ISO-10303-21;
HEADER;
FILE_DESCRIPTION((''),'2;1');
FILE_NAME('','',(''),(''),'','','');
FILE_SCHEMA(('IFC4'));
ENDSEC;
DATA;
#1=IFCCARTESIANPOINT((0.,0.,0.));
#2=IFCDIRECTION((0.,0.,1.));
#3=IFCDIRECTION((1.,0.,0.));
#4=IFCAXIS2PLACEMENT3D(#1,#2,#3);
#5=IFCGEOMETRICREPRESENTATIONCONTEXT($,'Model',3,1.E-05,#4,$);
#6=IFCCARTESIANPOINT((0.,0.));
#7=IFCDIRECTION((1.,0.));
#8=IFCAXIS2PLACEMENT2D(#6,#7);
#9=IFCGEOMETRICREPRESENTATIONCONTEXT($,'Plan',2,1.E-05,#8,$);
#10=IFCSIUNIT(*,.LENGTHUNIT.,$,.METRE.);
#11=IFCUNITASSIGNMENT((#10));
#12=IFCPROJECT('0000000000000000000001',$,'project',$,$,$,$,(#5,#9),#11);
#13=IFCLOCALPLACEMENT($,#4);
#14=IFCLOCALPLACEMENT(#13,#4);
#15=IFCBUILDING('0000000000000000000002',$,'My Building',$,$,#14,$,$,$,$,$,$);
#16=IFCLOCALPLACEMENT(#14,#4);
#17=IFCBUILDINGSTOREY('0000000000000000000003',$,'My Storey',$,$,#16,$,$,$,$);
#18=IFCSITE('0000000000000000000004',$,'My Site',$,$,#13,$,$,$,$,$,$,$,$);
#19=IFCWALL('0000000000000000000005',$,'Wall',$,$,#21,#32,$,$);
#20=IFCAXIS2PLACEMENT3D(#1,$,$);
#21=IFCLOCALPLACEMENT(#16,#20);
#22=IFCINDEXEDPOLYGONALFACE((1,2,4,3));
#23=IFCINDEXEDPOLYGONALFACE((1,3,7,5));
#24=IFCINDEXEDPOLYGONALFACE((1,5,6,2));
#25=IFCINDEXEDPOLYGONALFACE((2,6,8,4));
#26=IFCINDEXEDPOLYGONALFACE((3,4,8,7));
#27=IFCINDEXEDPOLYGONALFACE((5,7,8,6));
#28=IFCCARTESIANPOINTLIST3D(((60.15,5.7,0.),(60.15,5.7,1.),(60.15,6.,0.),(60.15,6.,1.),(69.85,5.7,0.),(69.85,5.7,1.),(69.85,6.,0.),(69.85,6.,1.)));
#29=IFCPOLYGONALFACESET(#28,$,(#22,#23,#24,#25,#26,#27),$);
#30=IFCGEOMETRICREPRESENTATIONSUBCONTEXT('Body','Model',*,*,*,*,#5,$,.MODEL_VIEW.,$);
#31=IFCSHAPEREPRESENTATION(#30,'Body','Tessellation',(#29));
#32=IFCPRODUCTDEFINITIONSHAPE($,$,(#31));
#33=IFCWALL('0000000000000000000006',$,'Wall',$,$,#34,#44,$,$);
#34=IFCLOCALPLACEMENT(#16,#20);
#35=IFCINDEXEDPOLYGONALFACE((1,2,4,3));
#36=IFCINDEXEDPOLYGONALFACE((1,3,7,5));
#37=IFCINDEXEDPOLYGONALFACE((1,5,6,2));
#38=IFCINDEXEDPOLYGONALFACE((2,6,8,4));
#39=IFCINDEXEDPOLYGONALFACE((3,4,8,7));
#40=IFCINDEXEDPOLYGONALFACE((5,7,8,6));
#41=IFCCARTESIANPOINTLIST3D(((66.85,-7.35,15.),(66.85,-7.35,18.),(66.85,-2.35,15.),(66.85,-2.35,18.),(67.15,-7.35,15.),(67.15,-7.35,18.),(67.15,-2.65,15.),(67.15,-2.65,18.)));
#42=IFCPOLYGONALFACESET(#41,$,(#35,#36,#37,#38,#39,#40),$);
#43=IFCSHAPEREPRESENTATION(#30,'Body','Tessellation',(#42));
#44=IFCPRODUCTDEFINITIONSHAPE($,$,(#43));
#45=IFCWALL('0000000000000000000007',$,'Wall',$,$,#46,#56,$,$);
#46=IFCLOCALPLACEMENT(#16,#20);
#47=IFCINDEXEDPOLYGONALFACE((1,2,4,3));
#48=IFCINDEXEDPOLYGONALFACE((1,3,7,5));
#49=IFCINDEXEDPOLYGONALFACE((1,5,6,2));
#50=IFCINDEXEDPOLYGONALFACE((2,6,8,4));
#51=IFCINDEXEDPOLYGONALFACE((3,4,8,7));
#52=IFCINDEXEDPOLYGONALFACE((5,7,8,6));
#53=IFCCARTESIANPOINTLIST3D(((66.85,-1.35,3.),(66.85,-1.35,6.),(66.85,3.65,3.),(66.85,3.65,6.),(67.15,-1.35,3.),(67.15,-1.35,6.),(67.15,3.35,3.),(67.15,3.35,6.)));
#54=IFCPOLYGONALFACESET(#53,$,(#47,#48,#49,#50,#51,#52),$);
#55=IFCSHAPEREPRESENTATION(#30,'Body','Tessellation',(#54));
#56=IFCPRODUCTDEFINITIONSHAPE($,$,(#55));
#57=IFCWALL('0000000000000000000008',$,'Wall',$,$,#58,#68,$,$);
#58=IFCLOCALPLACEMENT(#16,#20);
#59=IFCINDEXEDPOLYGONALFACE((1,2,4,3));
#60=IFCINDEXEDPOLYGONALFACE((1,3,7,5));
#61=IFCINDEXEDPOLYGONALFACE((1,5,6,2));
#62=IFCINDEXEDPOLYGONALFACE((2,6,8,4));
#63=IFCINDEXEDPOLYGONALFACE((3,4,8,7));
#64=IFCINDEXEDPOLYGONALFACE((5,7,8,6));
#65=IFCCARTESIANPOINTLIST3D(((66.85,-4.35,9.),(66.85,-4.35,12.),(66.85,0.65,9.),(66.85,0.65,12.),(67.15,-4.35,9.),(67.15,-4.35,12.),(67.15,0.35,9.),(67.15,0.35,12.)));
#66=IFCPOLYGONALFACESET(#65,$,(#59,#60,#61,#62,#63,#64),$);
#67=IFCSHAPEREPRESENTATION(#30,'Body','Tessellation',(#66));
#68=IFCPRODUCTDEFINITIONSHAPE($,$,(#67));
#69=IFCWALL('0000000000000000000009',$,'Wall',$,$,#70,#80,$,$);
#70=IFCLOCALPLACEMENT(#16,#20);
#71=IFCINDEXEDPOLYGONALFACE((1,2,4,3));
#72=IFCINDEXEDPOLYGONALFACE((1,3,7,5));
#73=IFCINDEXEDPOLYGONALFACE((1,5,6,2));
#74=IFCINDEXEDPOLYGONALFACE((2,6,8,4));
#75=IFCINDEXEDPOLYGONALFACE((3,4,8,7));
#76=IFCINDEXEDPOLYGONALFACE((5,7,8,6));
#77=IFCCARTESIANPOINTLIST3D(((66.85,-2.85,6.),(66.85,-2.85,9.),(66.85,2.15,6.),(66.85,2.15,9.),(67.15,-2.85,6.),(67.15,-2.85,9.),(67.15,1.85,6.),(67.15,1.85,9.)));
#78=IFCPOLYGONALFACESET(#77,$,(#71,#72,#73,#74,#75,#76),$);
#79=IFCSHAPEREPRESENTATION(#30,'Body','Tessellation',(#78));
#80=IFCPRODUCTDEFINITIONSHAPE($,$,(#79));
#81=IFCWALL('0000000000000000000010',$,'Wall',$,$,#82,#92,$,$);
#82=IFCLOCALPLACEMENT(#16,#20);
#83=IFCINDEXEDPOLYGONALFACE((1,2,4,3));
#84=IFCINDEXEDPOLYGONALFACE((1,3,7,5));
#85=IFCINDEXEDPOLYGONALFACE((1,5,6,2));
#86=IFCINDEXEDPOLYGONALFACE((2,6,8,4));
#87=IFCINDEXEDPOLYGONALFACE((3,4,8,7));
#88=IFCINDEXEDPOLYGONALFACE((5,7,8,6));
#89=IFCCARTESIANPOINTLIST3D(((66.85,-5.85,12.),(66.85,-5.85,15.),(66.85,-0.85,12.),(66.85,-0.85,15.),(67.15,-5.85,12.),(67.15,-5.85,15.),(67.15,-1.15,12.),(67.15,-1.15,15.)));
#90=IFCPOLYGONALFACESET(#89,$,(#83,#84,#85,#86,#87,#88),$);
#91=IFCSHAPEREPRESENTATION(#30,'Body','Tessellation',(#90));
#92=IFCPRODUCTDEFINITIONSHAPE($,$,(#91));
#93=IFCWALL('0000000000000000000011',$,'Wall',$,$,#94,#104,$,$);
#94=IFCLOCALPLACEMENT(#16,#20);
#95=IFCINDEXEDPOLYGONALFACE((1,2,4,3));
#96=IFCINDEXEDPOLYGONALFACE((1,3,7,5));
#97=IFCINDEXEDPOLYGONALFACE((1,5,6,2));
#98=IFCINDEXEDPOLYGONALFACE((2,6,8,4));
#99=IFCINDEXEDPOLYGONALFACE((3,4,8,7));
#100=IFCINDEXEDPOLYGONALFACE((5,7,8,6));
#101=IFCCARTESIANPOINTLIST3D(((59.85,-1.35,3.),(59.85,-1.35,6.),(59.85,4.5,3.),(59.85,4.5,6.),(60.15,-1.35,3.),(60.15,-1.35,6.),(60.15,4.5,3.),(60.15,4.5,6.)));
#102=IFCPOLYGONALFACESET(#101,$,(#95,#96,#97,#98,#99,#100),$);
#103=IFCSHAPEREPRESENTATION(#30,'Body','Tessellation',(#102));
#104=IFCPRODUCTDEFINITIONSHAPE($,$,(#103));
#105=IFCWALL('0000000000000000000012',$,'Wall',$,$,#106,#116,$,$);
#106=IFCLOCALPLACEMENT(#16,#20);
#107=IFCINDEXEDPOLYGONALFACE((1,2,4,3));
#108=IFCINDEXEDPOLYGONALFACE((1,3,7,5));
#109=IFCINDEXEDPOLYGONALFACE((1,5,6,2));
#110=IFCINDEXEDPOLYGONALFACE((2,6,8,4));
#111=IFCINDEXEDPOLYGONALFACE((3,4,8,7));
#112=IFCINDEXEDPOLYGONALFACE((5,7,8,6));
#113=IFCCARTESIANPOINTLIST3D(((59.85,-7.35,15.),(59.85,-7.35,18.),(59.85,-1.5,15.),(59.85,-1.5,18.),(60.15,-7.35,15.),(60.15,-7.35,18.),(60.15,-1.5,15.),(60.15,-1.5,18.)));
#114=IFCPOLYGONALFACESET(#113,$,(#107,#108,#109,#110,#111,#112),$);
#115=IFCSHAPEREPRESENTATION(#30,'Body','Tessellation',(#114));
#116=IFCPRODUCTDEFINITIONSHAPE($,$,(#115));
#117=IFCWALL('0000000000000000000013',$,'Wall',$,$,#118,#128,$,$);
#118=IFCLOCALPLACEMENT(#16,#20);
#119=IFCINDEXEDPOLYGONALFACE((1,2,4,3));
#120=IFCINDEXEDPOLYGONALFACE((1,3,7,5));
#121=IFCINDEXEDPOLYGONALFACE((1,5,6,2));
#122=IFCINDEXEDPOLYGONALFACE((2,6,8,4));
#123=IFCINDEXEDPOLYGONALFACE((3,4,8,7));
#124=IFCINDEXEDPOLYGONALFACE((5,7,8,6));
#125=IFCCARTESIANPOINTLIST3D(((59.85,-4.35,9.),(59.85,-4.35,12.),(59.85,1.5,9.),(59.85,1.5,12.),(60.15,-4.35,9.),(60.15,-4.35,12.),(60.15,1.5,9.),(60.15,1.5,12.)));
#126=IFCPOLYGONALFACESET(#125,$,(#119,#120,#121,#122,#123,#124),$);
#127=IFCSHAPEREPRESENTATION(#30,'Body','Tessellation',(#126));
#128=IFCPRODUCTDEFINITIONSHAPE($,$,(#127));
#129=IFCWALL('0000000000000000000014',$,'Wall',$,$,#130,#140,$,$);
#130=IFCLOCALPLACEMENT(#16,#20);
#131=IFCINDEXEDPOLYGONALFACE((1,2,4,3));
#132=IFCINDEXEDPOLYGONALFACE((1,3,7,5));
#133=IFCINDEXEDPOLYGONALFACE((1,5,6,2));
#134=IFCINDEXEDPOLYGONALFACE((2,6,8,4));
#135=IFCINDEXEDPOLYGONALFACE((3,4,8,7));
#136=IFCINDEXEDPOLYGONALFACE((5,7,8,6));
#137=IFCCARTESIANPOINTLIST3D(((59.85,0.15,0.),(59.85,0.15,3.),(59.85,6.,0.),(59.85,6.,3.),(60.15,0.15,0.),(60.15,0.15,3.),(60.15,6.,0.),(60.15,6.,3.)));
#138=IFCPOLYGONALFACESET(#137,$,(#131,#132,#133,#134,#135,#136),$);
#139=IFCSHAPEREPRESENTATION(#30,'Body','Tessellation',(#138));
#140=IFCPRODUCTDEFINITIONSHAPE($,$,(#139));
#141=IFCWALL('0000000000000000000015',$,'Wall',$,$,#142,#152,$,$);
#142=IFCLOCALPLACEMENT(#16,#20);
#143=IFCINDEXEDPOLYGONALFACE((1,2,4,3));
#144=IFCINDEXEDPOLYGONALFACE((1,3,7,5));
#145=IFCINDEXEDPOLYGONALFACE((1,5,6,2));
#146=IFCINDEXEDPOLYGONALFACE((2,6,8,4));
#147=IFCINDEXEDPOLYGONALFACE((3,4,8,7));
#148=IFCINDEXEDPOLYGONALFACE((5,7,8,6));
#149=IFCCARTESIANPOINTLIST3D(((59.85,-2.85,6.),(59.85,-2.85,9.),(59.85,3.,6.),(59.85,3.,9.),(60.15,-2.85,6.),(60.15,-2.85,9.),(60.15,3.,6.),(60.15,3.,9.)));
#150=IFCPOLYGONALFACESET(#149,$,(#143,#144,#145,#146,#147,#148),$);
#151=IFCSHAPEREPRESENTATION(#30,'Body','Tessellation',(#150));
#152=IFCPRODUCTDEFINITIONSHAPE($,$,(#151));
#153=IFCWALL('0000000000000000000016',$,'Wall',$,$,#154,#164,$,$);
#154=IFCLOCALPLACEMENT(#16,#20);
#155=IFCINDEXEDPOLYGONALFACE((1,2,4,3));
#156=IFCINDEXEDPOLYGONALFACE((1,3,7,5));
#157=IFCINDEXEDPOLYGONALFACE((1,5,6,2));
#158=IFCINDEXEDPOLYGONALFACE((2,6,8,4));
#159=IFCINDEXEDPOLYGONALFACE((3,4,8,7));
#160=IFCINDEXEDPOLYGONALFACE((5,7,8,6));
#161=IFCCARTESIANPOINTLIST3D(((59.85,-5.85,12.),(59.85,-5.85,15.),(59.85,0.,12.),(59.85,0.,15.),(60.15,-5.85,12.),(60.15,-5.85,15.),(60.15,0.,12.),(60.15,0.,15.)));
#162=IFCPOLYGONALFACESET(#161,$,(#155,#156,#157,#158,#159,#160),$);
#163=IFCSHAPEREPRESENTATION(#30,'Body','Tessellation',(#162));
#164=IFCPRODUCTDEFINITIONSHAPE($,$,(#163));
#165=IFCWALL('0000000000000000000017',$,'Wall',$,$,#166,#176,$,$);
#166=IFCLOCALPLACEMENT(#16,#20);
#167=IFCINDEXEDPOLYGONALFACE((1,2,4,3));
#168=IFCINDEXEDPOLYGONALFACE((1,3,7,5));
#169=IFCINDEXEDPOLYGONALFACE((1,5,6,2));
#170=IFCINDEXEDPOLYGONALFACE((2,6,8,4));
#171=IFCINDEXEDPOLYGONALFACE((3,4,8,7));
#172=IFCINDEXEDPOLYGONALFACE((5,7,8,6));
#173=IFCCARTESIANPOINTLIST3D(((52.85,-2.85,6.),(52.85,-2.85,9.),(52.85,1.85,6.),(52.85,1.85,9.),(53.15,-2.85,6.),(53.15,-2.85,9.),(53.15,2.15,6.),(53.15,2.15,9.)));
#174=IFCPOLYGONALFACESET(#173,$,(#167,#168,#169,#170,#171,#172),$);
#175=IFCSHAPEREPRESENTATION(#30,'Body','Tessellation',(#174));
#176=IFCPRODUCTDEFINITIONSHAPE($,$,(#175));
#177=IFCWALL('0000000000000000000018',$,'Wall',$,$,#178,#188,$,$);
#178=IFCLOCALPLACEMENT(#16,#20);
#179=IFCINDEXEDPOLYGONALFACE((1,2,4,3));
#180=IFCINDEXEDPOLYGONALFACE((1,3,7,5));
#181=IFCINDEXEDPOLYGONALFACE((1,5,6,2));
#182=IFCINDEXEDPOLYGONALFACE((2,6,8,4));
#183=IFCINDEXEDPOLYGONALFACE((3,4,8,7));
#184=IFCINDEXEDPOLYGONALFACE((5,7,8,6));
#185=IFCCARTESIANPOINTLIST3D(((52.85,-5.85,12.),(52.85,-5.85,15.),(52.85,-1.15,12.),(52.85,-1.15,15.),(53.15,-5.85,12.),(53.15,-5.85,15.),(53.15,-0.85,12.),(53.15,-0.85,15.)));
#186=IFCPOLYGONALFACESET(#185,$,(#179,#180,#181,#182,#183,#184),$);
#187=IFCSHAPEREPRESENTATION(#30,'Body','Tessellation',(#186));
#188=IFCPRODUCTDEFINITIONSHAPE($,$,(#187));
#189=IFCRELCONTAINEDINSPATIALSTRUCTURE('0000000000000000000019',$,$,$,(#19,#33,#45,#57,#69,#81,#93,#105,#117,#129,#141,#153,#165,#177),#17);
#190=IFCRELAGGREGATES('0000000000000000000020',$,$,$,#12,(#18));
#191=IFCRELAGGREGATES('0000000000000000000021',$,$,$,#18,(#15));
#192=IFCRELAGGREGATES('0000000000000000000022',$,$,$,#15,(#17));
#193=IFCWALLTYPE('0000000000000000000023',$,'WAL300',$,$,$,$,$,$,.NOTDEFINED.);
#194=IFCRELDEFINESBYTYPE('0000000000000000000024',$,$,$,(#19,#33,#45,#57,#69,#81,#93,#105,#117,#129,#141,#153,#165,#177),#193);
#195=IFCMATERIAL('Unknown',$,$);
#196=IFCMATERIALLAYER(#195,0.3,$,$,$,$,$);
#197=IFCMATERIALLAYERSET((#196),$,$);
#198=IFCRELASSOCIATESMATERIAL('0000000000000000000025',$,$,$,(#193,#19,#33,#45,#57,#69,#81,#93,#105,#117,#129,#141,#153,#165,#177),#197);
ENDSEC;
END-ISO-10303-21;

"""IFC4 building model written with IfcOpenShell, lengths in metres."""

from ifc_helpers import new_model, si_unit, frame, origin_with_axes, origin_2d_with_axis, place, context, subcontext, project, spatial, line, indexed_curve, outline, extrude, material, layer, layer_set, layer_usage, type_object, element, save


model = new_model("IFC4")

# Units and contexts
model_context = context("Model", 3, precision=1e-05, world=origin_with_axes())
plan_context = context("Plan", 2, precision=1e-05, world=origin_2d_with_axis())
body_context = subcontext(model_context, "Body", "Model", "MODEL_VIEW")
ifc_project = project(units=[si_unit("LENGTHUNIT", "METRE")], contexts=[model_context, plan_context])

# Site, building, storey
site_placement = place(None, origin_with_axes())
site = spatial("IfcSite", under=ifc_project, at=site_placement, Name="My Site")
building_placement = place(site_placement, origin_with_axes())
building = spatial("IfcBuilding", under=site, at=building_placement, Name="My Building")
storey_placement = place(building_placement, origin_with_axes())
storey = spatial("IfcBuildingStorey", under=building, at=storey_placement, Name="My Storey")

# Walls
ifc_material = material(Name="Unknown")
ifc_layer = layer(ifc_material, 0.3)
ifc_layer_set = layer_set([ifc_layer])
ifc_layer_usage_1 = layer_usage(ifc_layer_set, "AXIS2", "POSITIVE", -0.3)
wall_type = type_object("IfcWallType", Name="WAL300", PredefinedType="NOTDEFINED", material=ifc_layer_set)
wall_1_placement = place(storey_placement, frame((60.15, 6.0, 0.0), z_axis=(0.0, 0.0, 1.0), x_axis=(1.0, 0.0, 0.0)))
element("IfcWall", 1, at=wall_1_placement, inside=storey, type_object=wall_type, material=ifc_layer_usage_1, Name="Wall", context=body_context, shape_type="SweptSolid", body=[
    extrude(outline(indexed_curve([(0.0, -0.3), (0.0, 0.0), (9.7, 0.0), (9.7, -0.3)], segments=[line(1, 2, 3, 4, 1)])), origin_with_axes(), (0.0, 0.0, 1.0), 1.0),
])
ifc_layer_usage_2 = layer_usage(ifc_layer_set, "AXIS2", "POSITIVE", -0.15)
wall_2_placement = place(storey_placement, frame((67.0, -2.5, 15.0), z_axis=(0.0, 0.0, 1.0), x_axis=(0.0, -1.0, 0.0)))
element("IfcWall", 2, at=wall_2_placement, inside=storey, type_object=wall_type, material=ifc_layer_usage_2, Name="Wall", context=body_context, shape_type="SweptSolid", body=[
    extrude(outline(indexed_curve([(-0.15, -0.15), (0.15, 0.15), (4.85, 0.15), (4.85, -0.15)], segments=[line(1, 2, 3, 4, 1)])), origin_with_axes(), (0.0, 0.0, 1.0), 3.0),
])
ifc_layer_usage_3 = layer_usage(ifc_layer_set, "AXIS2", "POSITIVE", -0.15)
wall_3_placement = place(storey_placement, frame((67.0, 3.5, 3.0), z_axis=(0.0, 0.0, 1.0), x_axis=(0.0, -1.0, 0.0)))
element("IfcWall", 3, at=wall_3_placement, inside=storey, type_object=wall_type, material=ifc_layer_usage_3, Name="Wall", context=body_context, shape_type="SweptSolid", body=[
    extrude(outline(indexed_curve([(-0.15, -0.15), (0.15, 0.15), (4.85, 0.15), (4.85, -0.15)], segments=[line(1, 2, 3, 4, 1)])), origin_with_axes(), (0.0, 0.0, 1.0), 3.0),
])
ifc_layer_usage_4 = layer_usage(ifc_layer_set, "AXIS2", "POSITIVE", -0.15)
wall_4_placement = place(storey_placement, frame((67.0, 0.5, 9.0), z_axis=(0.0, 0.0, 1.0), x_axis=(0.0, -1.0, 0.0)))
element("IfcWall", 4, at=wall_4_placement, inside=storey, type_object=wall_type, material=ifc_layer_usage_4, Name="Wall", context=body_context, shape_type="SweptSolid", body=[
    extrude(outline(indexed_curve([(-0.15, -0.15), (0.15, 0.15), (4.85, 0.15), (4.85, -0.15)], segments=[line(1, 2, 3, 4, 1)])), origin_with_axes(), (0.0, 0.0, 1.0), 3.0),
])
ifc_layer_usage_5 = layer_usage(ifc_layer_set, "AXIS2", "POSITIVE", -0.15)
wall_5_placement = place(storey_placement, frame((67.0, 2.0, 6.0), z_axis=(0.0, 0.0, 1.0), x_axis=(0.0, -1.0, 0.0)))
element("IfcWall", 5, at=wall_5_placement, inside=storey, type_object=wall_type, material=ifc_layer_usage_5, Name="Wall", context=body_context, shape_type="SweptSolid", body=[
    extrude(outline(indexed_curve([(-0.15, -0.15), (0.15, 0.15), (4.85, 0.15), (4.85, -0.15)], segments=[line(1, 2, 3, 4, 1)])), origin_with_axes(), (0.0, 0.0, 1.0), 3.0),
])
ifc_layer_usage_6 = layer_usage(ifc_layer_set, "AXIS2", "POSITIVE", -0.15)
wall_6_placement = place(storey_placement, frame((67.0, -1.0, 12.0), z_axis=(0.0, 0.0, 1.0), x_axis=(0.0, -1.0, 0.0)))
element("IfcWall", 6, at=wall_6_placement, inside=storey, type_object=wall_type, material=ifc_layer_usage_6, Name="Wall", context=body_context, shape_type="SweptSolid", body=[
    extrude(outline(indexed_curve([(-0.15, -0.15), (0.15, 0.15), (4.85, 0.15), (4.85, -0.15)], segments=[line(1, 2, 3, 4, 1)])), origin_with_axes(), (0.0, 0.0, 1.0), 3.0),
])
ifc_layer_usage_7 = layer_usage(ifc_layer_set, "AXIS2", "POSITIVE", -0.15)
wall_7_placement = place(storey_placement, frame((60.0, -1.5, 3.0), z_axis=(0.0, 0.0, 1.0), x_axis=(0.0, 1.0, 0.0)))
element("IfcWall", 7, at=wall_7_placement, inside=storey, type_object=wall_type, material=ifc_layer_usage_7, Name="Wall", context=body_context, shape_type="SweptSolid", body=[
    extrude(outline(indexed_curve([(0.15, -0.15), (0.15, 0.15), (6.0, 0.15), (6.0, -0.15)], segments=[line(1, 2, 3, 4, 1)])), origin_with_axes(), (0.0, 0.0, 1.0), 3.0),
])
ifc_layer_usage_8 = layer_usage(ifc_layer_set, "AXIS2", "POSITIVE", -0.15)
wall_8_placement = place(storey_placement, frame((60.0, -7.5, 15.0), z_axis=(0.0, 0.0, 1.0), x_axis=(0.0, 1.0, 0.0)))
element("IfcWall", 8, at=wall_8_placement, inside=storey, type_object=wall_type, material=ifc_layer_usage_8, Name="Wall", context=body_context, shape_type="SweptSolid", body=[
    extrude(outline(indexed_curve([(0.15, -0.15), (0.15, 0.15), (6.0, 0.15), (6.0, -0.15)], segments=[line(1, 2, 3, 4, 1)])), origin_with_axes(), (0.0, 0.0, 1.0), 3.0),
])
ifc_layer_usage_9 = layer_usage(ifc_layer_set, "AXIS2", "POSITIVE", -0.15)
wall_9_placement = place(storey_placement, frame((60.0, -4.5, 9.0), z_axis=(0.0, 0.0, 1.0), x_axis=(0.0, 1.0, 0.0)))
element("IfcWall", 9, at=wall_9_placement, inside=storey, type_object=wall_type, material=ifc_layer_usage_9, Name="Wall", context=body_context, shape_type="SweptSolid", body=[
    extrude(outline(indexed_curve([(0.15, -0.15), (0.15, 0.15), (6.0, 0.15), (6.0, -0.15)], segments=[line(1, 2, 3, 4, 1)])), origin_with_axes(), (0.0, 0.0, 1.0), 3.0),
])
ifc_layer_usage_10 = layer_usage(ifc_layer_set, "AXIS2", "POSITIVE", -0.15)
wall_10_placement = place(storey_placement, frame((60.0, 0.0, 0.0), z_axis=(0.0, 0.0, 1.0), x_axis=(0.0, 1.0, 0.0)))
element("IfcWall", 10, at=wall_10_placement, inside=storey, type_object=wall_type, material=ifc_layer_usage_10, Name="Wall", context=body_context, shape_type="SweptSolid", body=[
    extrude(outline(indexed_curve([(0.15, -0.15), (0.15, 0.15), (6.0, 0.15), (6.0, -0.15)], segments=[line(1, 2, 3, 4, 1)])), origin_with_axes(), (0.0, 0.0, 1.0), 3.0),
])
ifc_layer_usage_11 = layer_usage(ifc_layer_set, "AXIS2", "POSITIVE", -0.15)
wall_11_placement = place(storey_placement, frame((60.0, -3.0, 6.0), z_axis=(0.0, 0.0, 1.0), x_axis=(0.0, 1.0, 0.0)))
element("IfcWall", 11, at=wall_11_placement, inside=storey, type_object=wall_type, material=ifc_layer_usage_11, Name="Wall", context=body_context, shape_type="SweptSolid", body=[
    extrude(outline(indexed_curve([(0.15, -0.15), (0.15, 0.15), (6.0, 0.15), (6.0, -0.15)], segments=[line(1, 2, 3, 4, 1)])), origin_with_axes(), (0.0, 0.0, 1.0), 3.0),
])
ifc_layer_usage_12 = layer_usage(ifc_layer_set, "AXIS2", "POSITIVE", -0.15)
wall_12_placement = place(storey_placement, frame((60.0, -6.0, 12.0), z_axis=(0.0, 0.0, 1.0), x_axis=(0.0, 1.0, 0.0)))
element("IfcWall", 12, at=wall_12_placement, inside=storey, type_object=wall_type, material=ifc_layer_usage_12, Name="Wall", context=body_context, shape_type="SweptSolid", body=[
    extrude(outline(indexed_curve([(0.15, -0.15), (0.15, 0.15), (6.0, 0.15), (6.0, -0.15)], segments=[line(1, 2, 3, 4, 1)])), origin_with_axes(), (0.0, 0.0, 1.0), 3.0),
])
ifc_layer_usage_13 = layer_usage(ifc_layer_set, "AXIS2", "POSITIVE", -0.15)
wall_13_placement = place(storey_placement, frame((53.0, -3.0, 6.0), z_axis=(0.0, 0.0, 1.0), x_axis=(0.0, 1.0, 0.0)))
element("IfcWall", 13, at=wall_13_placement, inside=storey, type_object=wall_type, material=ifc_layer_usage_13, Name="Wall", context=body_context, shape_type="SweptSolid", body=[
    extrude(outline(indexed_curve([(0.15, -0.15), (0.15, 0.15), (4.85, 0.15), (5.15, -0.15)], segments=[line(1, 2, 3, 4, 1)])), origin_with_axes(), (0.0, 0.0, 1.0), 3.0),
])
ifc_layer_usage_14 = layer_usage(ifc_layer_set, "AXIS2", "POSITIVE", -0.15)
wall_14_placement = place(storey_placement, frame((53.0, -6.0, 12.0), z_axis=(0.0, 0.0, 1.0), x_axis=(0.0, 1.0, 0.0)))
element("IfcWall", 14, at=wall_14_placement, inside=storey, type_object=wall_type, material=ifc_layer_usage_14, Name="Wall", context=body_context, shape_type="SweptSolid", body=[
    extrude(outline(indexed_curve([(0.15, -0.15), (0.15, 0.15), (4.85, 0.15), (5.15, -0.15)], segments=[line(1, 2, 3, 4, 1)])), origin_with_axes(), (0.0, 0.0, 1.0), 3.0),
])

save(model, "model.ifc")
